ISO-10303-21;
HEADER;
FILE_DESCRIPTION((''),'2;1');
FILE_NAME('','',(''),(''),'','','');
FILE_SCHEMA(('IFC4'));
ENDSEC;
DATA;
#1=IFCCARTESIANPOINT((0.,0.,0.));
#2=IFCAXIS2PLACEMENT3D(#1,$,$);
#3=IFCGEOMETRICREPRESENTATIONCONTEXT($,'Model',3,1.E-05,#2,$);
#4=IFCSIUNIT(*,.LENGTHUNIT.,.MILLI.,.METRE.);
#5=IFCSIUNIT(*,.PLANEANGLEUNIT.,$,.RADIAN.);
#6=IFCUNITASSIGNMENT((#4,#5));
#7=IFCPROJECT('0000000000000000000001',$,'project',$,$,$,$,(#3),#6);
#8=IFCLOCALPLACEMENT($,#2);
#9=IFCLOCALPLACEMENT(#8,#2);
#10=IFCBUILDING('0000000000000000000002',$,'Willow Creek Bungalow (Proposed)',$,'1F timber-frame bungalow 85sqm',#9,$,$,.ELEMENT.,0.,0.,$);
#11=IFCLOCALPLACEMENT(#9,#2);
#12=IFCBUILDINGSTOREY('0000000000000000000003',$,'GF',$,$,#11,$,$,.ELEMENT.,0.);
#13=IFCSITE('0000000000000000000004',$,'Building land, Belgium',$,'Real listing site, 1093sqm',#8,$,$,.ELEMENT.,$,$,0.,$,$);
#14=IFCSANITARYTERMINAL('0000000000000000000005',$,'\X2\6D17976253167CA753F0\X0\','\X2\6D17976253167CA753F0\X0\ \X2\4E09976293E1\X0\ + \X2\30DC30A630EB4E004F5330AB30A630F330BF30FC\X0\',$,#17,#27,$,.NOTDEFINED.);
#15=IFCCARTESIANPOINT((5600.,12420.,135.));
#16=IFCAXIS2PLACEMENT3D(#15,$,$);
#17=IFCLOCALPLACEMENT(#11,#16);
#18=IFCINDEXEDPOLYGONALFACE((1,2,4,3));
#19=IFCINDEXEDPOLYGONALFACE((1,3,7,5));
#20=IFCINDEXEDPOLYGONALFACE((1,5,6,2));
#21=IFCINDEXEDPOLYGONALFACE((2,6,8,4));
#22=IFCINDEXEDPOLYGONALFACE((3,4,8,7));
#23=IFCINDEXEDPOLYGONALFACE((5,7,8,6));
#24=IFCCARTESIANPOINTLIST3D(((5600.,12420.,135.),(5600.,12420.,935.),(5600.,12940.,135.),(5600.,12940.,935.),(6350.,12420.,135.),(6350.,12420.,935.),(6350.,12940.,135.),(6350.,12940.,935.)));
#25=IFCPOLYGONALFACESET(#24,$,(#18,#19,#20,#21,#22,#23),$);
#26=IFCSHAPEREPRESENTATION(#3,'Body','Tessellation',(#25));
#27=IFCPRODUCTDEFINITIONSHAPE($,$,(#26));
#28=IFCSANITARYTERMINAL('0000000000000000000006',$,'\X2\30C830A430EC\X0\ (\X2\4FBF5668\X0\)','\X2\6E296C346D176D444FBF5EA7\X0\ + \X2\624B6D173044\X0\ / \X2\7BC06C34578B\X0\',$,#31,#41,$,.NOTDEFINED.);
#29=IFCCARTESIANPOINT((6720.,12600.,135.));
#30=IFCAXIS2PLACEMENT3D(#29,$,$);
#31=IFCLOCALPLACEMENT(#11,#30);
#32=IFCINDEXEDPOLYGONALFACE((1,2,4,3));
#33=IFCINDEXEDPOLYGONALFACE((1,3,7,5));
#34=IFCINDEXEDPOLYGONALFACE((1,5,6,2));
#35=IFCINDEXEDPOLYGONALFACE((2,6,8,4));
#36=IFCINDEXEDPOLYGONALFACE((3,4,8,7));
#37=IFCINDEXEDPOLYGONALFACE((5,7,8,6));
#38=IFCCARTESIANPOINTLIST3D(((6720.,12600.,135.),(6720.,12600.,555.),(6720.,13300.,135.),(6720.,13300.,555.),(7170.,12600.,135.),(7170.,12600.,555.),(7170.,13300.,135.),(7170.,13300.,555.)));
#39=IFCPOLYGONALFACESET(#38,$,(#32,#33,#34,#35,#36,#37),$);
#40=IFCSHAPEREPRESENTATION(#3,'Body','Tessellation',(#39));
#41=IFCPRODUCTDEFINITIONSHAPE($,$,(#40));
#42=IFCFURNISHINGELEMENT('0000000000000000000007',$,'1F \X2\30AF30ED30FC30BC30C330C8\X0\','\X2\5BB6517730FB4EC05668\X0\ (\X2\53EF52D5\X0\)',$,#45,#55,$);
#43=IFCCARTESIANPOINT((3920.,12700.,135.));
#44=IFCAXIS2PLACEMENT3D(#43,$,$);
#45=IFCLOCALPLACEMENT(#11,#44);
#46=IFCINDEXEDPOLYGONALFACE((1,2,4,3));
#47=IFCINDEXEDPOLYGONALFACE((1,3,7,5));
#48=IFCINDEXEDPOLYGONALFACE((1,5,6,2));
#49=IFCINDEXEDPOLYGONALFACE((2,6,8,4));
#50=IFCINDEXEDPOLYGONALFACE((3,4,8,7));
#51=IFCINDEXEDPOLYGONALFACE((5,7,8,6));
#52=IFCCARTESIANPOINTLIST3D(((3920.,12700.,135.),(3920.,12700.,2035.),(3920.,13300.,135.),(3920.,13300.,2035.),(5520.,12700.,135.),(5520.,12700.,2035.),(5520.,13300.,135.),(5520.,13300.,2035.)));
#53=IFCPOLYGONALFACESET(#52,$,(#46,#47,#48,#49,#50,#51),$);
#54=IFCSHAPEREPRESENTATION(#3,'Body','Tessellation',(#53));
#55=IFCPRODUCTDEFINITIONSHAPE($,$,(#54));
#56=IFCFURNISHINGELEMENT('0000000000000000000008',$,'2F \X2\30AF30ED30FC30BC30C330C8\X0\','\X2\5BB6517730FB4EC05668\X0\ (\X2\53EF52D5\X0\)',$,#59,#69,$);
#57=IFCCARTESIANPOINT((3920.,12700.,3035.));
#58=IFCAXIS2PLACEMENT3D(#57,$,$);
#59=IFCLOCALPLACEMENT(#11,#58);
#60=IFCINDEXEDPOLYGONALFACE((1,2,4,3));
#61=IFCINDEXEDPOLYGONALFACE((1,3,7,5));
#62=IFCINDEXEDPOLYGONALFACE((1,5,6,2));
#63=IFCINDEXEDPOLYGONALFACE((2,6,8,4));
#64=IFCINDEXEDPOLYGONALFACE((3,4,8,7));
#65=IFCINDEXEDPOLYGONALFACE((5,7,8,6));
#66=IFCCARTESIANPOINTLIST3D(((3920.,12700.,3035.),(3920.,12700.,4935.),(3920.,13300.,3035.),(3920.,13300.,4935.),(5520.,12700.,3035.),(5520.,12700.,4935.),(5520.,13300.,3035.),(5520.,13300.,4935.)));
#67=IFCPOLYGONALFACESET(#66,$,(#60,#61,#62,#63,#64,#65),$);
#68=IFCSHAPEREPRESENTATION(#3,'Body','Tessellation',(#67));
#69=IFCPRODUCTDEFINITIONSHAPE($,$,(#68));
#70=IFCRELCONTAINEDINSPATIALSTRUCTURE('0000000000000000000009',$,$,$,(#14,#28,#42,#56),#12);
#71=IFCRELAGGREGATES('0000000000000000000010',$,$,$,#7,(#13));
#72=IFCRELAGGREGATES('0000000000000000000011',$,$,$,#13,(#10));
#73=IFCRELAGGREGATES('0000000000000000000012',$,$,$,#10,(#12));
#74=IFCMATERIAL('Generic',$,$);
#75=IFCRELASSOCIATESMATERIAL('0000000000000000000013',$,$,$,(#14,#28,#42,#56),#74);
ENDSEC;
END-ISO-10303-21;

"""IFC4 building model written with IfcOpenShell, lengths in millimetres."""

from ifc_helpers import new_model, si_unit, frame, frame_2d, origin, place, context, project, spatial, rectangle, extrude, material, element, save


model = new_model("IFC4")

# Units and contexts
model_context = context("Model", 3, precision=1e-05, world=origin())
ifc_project = project(units=[si_unit("LENGTHUNIT", "METRE", prefix="MILLI"), si_unit("PLANEANGLEUNIT", "RADIAN")], contexts=[model_context])

# Site, building, storey
site_placement = place(None, origin())
site = spatial("IfcSite", under=ifc_project, at=site_placement, Name="Building land, Belgium", ObjectType="Real listing site, 1093sqm", CompositionType="ELEMENT", RefElevation=0.0)
building_placement = place(site_placement, origin())
building = spatial("IfcBuilding", under=site, at=building_placement, Name="Willow Creek Bungalow (Proposed)", ObjectType="1F timber-frame bungalow 85sqm", CompositionType="ELEMENT", ElevationOfRefHeight=0.0, ElevationOfTerrain=0.0)
storey_placement = place(building_placement, origin())
storey = spatial("IfcBuildingStorey", under=building, at=storey_placement, Name="GF", CompositionType="ELEMENT", Elevation=0.0)

# Shared definitions
ifc_material_1 = material(Name="Generic")

# Sanitary terminals
sanitary_terminal_1_placement = place(storey_placement, frame((5600.0, 12420.0, 135.0)))
element("IfcSanitaryTerminal", 1, at=sanitary_terminal_1_placement, inside=storey, material=ifc_material_1, Name="洗面化粧台", Description="洗面化粧台 三面鏡 + ボウル一体カウンター", PredefinedType="NOTDEFINED", context=model_context, shape_type="SweptSolid", body=[
    extrude(rectangle(XDim=750.0, YDim=520.0, at=frame_2d((375.0, 260.0))), frame((5600.0, 12420.0, 135.0)), (0.0, 0.0, 1.0), 800.0),
])
sanitary_terminal_2_placement = place(storey_placement, frame((6720.0, 12600.0, 135.0)))
element("IfcSanitaryTerminal", 2, at=sanitary_terminal_2_placement, inside=storey, material=ifc_material_1, Name="トイレ (便器)", Description="温水洗浄便座 + 手洗い / 節水型", PredefinedType="NOTDEFINED", context=model_context, shape_type="SweptSolid", body=[
    extrude(rectangle(XDim=450.0, YDim=700.0, at=frame_2d((225.0, 350.0))), frame((6720.0, 12600.0, 135.0)), (0.0, 0.0, 1.0), 420.0),
])

# Furnishing elements
furnishing_1_placement = place(storey_placement, frame((3920.0, 12700.0, 135.0)))
element("IfcFurnishingElement", 3, at=furnishing_1_placement, inside=storey, material=ifc_material_1, Name="1F クローゼット", Description="家具・什器 (可動)", context=model_context, shape_type="SweptSolid", body=[
    extrude(rectangle(XDim=1600.0, YDim=600.0, at=frame_2d((800.0, 300.0))), frame((3920.0, 12700.0, 135.0)), (0.0, 0.0, 1.0), 1900.0),
])
furnishing_2_placement = place(storey_placement, frame((3920.0, 12700.0, 3035.0)))
element("IfcFurnishingElement", 4, at=furnishing_2_placement, inside=storey, material=ifc_material_1, Name="2F クローゼット", Description="家具・什器 (可動)", context=model_context, shape_type="SweptSolid", body=[
    extrude(rectangle(XDim=1600.0, YDim=600.0, at=frame_2d((800.0, 300.0))), frame((3920.0, 12700.0, 3035.0)), (0.0, 0.0, 1.0), 1900.0),
])

save(model, "model.ifc")
